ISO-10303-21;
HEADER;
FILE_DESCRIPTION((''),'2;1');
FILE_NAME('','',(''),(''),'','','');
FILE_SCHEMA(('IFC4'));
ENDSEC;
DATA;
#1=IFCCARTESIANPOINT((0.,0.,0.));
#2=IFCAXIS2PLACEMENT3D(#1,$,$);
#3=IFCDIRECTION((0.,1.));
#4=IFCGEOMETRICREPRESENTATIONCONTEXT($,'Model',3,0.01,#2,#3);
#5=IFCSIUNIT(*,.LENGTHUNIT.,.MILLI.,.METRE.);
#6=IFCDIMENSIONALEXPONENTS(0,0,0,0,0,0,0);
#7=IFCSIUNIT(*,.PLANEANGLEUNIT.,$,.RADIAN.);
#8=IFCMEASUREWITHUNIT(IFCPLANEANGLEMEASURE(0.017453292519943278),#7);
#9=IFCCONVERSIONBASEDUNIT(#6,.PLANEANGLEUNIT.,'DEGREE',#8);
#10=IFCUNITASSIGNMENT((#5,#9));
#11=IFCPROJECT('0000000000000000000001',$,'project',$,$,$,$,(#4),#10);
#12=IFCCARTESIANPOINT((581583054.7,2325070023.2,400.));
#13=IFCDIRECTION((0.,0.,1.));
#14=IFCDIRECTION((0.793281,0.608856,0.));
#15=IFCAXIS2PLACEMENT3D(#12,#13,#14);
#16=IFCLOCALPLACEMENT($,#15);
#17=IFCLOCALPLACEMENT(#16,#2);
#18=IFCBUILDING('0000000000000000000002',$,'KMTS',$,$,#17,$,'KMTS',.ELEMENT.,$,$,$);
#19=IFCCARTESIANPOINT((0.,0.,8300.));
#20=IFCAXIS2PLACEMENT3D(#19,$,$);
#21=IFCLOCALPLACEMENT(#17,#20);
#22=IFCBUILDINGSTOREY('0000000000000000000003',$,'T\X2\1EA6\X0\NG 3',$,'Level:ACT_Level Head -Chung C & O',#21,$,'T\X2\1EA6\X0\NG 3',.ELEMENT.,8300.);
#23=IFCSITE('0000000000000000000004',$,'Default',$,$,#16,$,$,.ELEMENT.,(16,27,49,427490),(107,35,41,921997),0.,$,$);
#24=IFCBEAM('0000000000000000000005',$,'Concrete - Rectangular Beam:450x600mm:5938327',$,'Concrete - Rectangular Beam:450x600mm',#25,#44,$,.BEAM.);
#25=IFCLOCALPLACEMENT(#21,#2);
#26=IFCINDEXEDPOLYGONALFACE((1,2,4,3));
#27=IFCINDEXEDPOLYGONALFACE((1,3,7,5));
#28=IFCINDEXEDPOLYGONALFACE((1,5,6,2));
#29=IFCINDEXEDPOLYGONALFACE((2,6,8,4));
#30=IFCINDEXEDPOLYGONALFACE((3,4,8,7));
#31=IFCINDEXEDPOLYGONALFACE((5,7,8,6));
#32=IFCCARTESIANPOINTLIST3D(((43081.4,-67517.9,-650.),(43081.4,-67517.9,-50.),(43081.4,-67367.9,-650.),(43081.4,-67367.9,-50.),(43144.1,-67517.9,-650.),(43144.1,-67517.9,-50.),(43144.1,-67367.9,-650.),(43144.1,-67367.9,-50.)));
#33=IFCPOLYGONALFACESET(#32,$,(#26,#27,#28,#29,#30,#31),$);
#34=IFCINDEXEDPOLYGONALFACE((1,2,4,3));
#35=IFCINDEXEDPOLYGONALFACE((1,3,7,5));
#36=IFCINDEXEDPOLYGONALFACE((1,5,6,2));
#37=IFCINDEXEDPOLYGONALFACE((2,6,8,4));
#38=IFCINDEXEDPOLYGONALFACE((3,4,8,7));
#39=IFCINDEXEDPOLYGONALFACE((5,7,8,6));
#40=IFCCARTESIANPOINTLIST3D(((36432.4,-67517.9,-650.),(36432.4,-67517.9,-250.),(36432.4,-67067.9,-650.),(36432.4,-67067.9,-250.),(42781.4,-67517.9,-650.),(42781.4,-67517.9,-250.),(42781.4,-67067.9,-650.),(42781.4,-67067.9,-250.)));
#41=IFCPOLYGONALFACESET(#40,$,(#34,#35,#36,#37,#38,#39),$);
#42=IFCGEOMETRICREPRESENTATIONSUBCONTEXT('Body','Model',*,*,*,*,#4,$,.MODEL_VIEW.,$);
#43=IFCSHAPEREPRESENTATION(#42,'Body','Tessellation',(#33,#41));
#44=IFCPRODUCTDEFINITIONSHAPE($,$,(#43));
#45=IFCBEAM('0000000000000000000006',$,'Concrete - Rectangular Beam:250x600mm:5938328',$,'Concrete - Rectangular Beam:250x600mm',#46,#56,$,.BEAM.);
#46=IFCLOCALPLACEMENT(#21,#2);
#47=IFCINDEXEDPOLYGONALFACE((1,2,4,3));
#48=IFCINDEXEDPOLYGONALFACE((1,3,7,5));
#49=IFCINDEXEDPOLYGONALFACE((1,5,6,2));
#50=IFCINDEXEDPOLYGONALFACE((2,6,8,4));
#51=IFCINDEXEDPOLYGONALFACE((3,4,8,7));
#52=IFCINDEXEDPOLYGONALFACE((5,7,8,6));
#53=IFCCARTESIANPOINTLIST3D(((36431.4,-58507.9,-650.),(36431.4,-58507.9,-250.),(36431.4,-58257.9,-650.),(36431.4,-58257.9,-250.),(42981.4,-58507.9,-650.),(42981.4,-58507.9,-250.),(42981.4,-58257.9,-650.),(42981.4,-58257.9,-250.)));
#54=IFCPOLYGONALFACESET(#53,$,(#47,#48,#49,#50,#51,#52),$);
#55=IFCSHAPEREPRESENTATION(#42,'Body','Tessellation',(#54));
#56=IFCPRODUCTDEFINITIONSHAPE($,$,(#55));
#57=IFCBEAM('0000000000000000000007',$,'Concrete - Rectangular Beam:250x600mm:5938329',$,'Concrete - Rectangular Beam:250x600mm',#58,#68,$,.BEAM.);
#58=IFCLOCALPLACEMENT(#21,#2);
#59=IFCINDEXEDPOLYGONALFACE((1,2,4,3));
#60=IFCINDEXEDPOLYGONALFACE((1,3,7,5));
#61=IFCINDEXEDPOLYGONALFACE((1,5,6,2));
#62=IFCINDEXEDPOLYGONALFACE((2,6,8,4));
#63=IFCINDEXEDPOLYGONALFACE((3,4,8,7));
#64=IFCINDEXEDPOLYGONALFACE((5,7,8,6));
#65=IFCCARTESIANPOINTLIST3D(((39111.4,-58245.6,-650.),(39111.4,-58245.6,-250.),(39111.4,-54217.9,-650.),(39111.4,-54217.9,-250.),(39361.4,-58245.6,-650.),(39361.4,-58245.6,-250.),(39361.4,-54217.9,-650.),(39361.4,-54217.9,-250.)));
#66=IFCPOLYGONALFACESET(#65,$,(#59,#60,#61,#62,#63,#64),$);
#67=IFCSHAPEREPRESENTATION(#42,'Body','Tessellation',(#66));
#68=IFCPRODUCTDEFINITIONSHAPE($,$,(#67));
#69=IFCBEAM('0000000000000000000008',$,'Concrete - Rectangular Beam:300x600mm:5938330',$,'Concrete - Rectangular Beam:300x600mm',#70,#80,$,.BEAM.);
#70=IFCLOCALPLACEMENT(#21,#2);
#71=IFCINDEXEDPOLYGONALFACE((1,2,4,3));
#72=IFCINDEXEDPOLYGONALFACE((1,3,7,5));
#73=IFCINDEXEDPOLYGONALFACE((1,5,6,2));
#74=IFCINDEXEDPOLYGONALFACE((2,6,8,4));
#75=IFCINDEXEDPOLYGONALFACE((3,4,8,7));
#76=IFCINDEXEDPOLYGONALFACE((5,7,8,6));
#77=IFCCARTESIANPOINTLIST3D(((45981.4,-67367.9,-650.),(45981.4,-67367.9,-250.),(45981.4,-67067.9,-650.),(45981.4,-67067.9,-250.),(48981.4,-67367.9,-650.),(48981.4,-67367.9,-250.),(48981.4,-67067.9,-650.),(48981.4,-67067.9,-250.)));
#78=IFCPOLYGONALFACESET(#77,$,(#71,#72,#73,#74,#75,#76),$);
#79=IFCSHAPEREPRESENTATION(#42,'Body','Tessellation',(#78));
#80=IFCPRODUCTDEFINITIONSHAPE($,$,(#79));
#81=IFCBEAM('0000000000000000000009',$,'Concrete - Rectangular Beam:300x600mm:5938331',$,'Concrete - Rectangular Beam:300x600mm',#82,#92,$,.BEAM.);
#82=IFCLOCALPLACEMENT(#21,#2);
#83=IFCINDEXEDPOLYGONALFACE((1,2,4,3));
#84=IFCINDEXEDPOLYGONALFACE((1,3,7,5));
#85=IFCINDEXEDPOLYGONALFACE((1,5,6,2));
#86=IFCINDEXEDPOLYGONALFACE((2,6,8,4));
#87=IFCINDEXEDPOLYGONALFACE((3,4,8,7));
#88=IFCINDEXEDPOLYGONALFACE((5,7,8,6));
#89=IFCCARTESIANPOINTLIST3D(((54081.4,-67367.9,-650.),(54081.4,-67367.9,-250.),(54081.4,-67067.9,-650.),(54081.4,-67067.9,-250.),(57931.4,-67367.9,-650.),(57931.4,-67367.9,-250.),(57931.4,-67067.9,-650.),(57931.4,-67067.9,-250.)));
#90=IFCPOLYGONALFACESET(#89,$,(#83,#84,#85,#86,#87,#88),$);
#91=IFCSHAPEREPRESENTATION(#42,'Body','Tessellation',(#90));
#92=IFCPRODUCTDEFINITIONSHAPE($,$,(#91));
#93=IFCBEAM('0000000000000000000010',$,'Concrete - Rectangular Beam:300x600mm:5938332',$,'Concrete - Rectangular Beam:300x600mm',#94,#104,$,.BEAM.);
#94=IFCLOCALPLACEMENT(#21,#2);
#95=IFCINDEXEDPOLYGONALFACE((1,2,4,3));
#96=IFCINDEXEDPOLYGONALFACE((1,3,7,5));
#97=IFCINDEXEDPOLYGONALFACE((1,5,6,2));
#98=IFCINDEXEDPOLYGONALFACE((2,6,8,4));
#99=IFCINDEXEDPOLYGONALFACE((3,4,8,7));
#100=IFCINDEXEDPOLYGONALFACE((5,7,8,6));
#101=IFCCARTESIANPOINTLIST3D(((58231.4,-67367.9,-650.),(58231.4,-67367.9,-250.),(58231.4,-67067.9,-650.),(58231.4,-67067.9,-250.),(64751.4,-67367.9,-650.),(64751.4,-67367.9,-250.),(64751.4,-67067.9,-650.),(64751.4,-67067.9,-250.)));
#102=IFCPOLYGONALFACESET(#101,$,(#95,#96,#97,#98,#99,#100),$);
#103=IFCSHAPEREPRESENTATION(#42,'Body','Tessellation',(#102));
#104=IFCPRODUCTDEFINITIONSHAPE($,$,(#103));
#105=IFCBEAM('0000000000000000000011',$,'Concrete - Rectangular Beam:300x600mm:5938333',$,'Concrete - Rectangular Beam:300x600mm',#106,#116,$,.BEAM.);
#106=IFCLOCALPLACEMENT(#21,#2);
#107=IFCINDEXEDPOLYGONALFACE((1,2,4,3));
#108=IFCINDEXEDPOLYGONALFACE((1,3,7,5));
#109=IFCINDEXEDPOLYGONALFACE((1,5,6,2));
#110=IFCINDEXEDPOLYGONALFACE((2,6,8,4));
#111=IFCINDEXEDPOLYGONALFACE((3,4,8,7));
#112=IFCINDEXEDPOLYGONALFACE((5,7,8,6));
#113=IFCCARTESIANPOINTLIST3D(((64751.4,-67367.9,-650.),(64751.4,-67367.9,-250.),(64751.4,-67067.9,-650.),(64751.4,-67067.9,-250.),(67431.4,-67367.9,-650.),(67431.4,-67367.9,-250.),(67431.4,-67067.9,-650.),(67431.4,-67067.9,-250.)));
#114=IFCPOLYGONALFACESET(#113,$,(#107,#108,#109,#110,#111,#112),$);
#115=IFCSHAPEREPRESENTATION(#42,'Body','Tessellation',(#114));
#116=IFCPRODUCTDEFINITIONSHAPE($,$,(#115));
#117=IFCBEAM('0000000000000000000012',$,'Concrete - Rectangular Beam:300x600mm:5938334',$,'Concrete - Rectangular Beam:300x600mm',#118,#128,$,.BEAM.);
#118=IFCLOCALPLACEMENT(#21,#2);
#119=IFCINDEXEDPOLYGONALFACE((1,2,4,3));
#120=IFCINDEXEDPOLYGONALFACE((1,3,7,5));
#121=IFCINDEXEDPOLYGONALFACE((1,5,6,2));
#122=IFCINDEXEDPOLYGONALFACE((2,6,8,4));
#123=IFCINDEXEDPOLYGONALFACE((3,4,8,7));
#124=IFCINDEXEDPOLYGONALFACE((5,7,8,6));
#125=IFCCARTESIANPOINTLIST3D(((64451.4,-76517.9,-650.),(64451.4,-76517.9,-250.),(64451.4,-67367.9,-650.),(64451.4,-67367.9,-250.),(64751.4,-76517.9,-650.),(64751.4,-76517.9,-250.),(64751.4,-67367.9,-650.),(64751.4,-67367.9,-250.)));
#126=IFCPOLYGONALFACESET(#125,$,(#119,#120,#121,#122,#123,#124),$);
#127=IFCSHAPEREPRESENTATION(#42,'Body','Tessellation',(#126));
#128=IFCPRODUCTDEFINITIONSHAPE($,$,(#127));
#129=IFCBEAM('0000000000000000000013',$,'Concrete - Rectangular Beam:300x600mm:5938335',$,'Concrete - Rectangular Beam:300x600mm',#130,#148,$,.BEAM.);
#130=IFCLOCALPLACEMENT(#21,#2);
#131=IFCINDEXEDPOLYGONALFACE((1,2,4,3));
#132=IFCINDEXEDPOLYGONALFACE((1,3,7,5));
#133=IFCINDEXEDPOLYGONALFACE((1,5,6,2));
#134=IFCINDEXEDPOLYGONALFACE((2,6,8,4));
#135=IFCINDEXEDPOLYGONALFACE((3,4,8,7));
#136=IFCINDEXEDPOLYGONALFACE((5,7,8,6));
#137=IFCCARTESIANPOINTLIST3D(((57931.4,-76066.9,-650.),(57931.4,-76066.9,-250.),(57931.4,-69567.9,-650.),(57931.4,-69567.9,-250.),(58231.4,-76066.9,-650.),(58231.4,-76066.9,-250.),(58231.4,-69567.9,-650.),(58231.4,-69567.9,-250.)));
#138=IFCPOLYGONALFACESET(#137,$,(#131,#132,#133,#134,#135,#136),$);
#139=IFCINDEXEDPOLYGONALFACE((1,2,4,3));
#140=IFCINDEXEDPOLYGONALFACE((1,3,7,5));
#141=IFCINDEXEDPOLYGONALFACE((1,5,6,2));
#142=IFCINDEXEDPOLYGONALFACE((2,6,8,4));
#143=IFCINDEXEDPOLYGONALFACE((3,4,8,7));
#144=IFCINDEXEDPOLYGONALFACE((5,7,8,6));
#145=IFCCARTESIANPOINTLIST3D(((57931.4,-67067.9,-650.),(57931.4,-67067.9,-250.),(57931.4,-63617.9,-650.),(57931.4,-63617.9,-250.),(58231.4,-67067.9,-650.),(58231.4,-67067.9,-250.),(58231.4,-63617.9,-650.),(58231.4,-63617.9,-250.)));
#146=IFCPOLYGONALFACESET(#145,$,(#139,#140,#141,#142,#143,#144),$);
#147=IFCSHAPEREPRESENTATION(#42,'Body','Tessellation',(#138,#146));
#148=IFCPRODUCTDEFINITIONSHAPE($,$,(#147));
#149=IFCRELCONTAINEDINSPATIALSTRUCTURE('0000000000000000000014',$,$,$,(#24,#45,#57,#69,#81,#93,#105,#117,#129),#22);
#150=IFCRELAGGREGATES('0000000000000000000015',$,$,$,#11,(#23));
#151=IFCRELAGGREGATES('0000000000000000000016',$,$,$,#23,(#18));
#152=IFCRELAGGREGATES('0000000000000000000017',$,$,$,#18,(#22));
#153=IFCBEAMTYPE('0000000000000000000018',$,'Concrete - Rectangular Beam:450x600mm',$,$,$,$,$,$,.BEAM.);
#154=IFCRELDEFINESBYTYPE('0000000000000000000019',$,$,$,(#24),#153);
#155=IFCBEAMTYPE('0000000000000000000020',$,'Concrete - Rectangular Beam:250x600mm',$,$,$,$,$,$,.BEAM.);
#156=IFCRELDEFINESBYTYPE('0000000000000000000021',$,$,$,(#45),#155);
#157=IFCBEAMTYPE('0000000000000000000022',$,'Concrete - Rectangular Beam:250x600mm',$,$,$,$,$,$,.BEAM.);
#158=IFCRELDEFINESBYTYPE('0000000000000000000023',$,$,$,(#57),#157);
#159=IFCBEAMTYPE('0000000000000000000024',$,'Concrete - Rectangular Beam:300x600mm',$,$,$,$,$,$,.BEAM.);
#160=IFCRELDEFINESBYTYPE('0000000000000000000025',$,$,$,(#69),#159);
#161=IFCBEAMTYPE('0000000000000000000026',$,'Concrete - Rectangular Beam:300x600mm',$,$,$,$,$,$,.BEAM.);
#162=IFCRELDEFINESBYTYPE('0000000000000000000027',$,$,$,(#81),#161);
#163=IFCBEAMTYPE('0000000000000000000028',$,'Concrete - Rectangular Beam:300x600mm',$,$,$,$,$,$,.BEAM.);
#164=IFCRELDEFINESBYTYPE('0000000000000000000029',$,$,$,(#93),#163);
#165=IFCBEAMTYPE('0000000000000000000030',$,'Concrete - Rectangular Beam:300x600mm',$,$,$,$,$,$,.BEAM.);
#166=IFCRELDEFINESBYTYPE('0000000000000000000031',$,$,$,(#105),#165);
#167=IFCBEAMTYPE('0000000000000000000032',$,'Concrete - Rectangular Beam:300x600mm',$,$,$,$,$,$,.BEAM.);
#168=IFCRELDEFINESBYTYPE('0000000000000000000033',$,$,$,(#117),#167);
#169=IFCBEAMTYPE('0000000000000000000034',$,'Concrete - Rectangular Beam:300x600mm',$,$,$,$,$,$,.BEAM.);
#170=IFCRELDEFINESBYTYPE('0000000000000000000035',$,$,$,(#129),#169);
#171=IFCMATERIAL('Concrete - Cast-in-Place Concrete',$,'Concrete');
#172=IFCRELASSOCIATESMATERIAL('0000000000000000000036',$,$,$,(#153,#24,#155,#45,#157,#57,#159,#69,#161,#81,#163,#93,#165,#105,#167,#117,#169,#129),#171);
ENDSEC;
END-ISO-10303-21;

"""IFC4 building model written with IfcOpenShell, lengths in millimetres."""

from ifc_helpers import new_model, entity, si_unit, converted_unit, direction, frame, origin, place, context, subcontext, project, spatial, indexed_curve, outline, extrude, source, transform, mapped, material, type_object, type_shapes, element, save


model = new_model("IFC4")

# Units and contexts
model_context = context("Model", 3, precision=0.01, world=origin(), true_north=direction((0.0, 1.0)))
body_context = subcontext(model_context, "Body", "Model", "MODEL_VIEW")
ifc_project = project(units=[si_unit("LENGTHUNIT", "METRE", prefix="MILLI"), converted_unit("PLANEANGLEUNIT", "DEGREE", entity("IfcPlaneAngleMeasure", 0.017453292519943278), si_unit("PLANEANGLEUNIT", "RADIAN"), dimensions=[0, 0, 0, 0, 0, 0, 0])], contexts=[model_context])

# Site, building, storey
site_placement = place(None, frame((581583054.7, 2325070023.2, 400.0), z_axis=(0.0, 0.0, 1.0), x_axis=(0.793281, 0.608856, 0.0)))
site = spatial("IfcSite", under=ifc_project, at=site_placement, Name="Default", CompositionType="ELEMENT", RefLatitude=(16, 27, 49, 427490), RefLongitude=(107, 35, 41, 921997), RefElevation=0.0)
building_placement = place(site_placement, origin())
building = spatial("IfcBuilding", under=site, at=building_placement, Name="KMTS", LongName="KMTS", CompositionType="ELEMENT")
storey_placement = place(building_placement, frame((0.0, 0.0, 8300.0)))
storey = spatial("IfcBuildingStorey", under=building, at=storey_placement, Name="TẦNG 3", ObjectType="Level:ACT_Level Head -Chung C & O", LongName="TẦNG 3", CompositionType="ELEMENT", Elevation=8300.0)

# Beams
ifc_material_1 = material(Name="Concrete - Cast-in-Place Concrete", Category="Concrete")
beam_type_1 = type_object("IfcBeamType", Name="Concrete - Rectangular Beam:450x600mm", PredefinedType="BEAM", material=ifc_material_1)
shared_shape_1 = source(origin(), body_context, "Body", "SweptSolid", [
    extrude(outline(indexed_curve([(-300.0, -75.0), (300.0, -75.0), (300.0, 75.0), (-300.0, 75.0), (-300.0, -75.0)], self_intersect=False)), frame((43081.4, -67442.9, 7950.0), z_axis=(1.0, 0.0, 0.0), x_axis=(0.0, 0.0, -1.0)), (0.0, 0.0, 1.0), 62.7),
    extrude(outline(indexed_curve([(-200.0, -225.0), (200.0, -225.0), (200.0, 225.0), (-200.0, 225.0), (-200.0, -225.0)], self_intersect=False)), frame((36432.4, -67292.9, 7850.0), z_axis=(1.0, 0.0, 0.0), x_axis=(0.0, 0.0, -1.0)), (0.0, 0.0, 1.0), 6349.0),
])
type_shapes(beam_type_1, [shared_shape_1])
beam_1_placement = place(storey_placement, frame((0.0, 0.0, -8300.0)))
element("IfcBeam", 1, at=beam_1_placement, inside=storey, type_object=beam_type_1, material=ifc_material_1, Name="Concrete - Rectangular Beam:450x600mm:5938327", ObjectType="Concrete - Rectangular Beam:450x600mm", PredefinedType="BEAM", context=body_context, shape_type="MappedRepresentation", body=[
    mapped(shared_shape_1, transform((0.0, 0.0, 0.0), scale=1.0)),
])
beam_type_2 = type_object("IfcBeamType", Name="Concrete - Rectangular Beam:250x600mm", PredefinedType="BEAM", material=ifc_material_1)
shared_shape_2 = source(origin(), body_context, "Body", "SweptSolid", [
    extrude(outline(indexed_curve([(-200.0, -125.0), (200.0, -125.0), (200.0, 125.0), (-200.0, 125.0), (-200.0, -125.0)], self_intersect=False)), frame((42981.4, -58382.9, 7850.0), z_axis=(-1.0, 0.0, 0.0), x_axis=(0.0, 0.0, -1.0)), (0.0, 0.0, 1.0), 6550.0),
])
type_shapes(beam_type_2, [shared_shape_2])
beam_2_placement = place(storey_placement, frame((0.0, 0.0, -8300.0)))
element("IfcBeam", 2, at=beam_2_placement, inside=storey, type_object=beam_type_2, material=ifc_material_1, Name="Concrete - Rectangular Beam:250x600mm:5938328", ObjectType="Concrete - Rectangular Beam:250x600mm", PredefinedType="BEAM", context=body_context, shape_type="MappedRepresentation", body=[
    mapped(shared_shape_2, transform((0.0, 0.0, 0.0), scale=1.0)),
])
beam_type_3 = type_object("IfcBeamType", Name="Concrete - Rectangular Beam:250x600mm", PredefinedType="BEAM", material=ifc_material_1)
shared_shape_3 = source(origin(), body_context, "Body", "SweptSolid", [
    extrude(outline(indexed_curve([(-125.0, -200.0), (125.0, -200.0), (125.0, 200.0), (-125.0, 200.0), (-125.0, -200.0)], self_intersect=False)), frame((39236.4, -54217.9, 7850.0), z_axis=(0.0, -1.0, 0.0), x_axis=(-1.0, 0.0, 0.0)), (0.0, 0.0, 1.0), 4027.7),
])
type_shapes(beam_type_3, [shared_shape_3])
beam_3_placement = place(storey_placement, frame((0.0, 0.0, -8300.0)))
element("IfcBeam", 3, at=beam_3_placement, inside=storey, type_object=beam_type_3, material=ifc_material_1, Name="Concrete - Rectangular Beam:250x600mm:5938329", ObjectType="Concrete - Rectangular Beam:250x600mm", PredefinedType="BEAM", context=body_context, shape_type="MappedRepresentation", body=[
    mapped(shared_shape_3, transform((0.0, 0.0, 0.0), scale=1.0)),
])
beam_type_4 = type_object("IfcBeamType", Name="Concrete - Rectangular Beam:300x600mm", PredefinedType="BEAM", material=ifc_material_1)
shared_shape_4 = source(origin(), body_context, "Body", "SweptSolid", [
    extrude(outline(indexed_curve([(-200.0, -150.0), (200.0, -150.0), (200.0, 150.0), (-200.0, 150.0), (-200.0, -150.0)], self_intersect=False)), frame((48981.4, -67217.9, 7850.0), z_axis=(-1.0, 0.0, 0.0), x_axis=(0.0, 0.0, -1.0)), (0.0, 0.0, 1.0), 3000.0),
])
type_shapes(beam_type_4, [shared_shape_4])
beam_4_placement = place(storey_placement, frame((0.0, 0.0, -8300.0)))
element("IfcBeam", 4, at=beam_4_placement, inside=storey, type_object=beam_type_4, material=ifc_material_1, Name="Concrete - Rectangular Beam:300x600mm:5938330", ObjectType="Concrete - Rectangular Beam:300x600mm", PredefinedType="BEAM", context=body_context, shape_type="MappedRepresentation", body=[
    mapped(shared_shape_4, transform((0.0, 0.0, 0.0), scale=1.0)),
])
beam_type_5 = type_object("IfcBeamType", Name="Concrete - Rectangular Beam:300x600mm", PredefinedType="BEAM", material=ifc_material_1)
shared_shape_5 = source(origin(), body_context, "Body", "SweptSolid", [
    extrude(outline(indexed_curve([(-200.0, -150.0), (200.0, -150.0), (200.0, 150.0), (-200.0, 150.0), (-200.0, -150.0)], self_intersect=False)), frame((54081.4, -67217.9, 7850.0), z_axis=(1.0, 0.0, 0.0), x_axis=(0.0, 0.0, -1.0)), (0.0, 0.0, 1.0), 3850.0),
])
type_shapes(beam_type_5, [shared_shape_5])
beam_5_placement = place(storey_placement, frame((0.0, 0.0, -8300.0)))
element("IfcBeam", 5, at=beam_5_placement, inside=storey, type_object=beam_type_5, material=ifc_material_1, Name="Concrete - Rectangular Beam:300x600mm:5938331", ObjectType="Concrete - Rectangular Beam:300x600mm", PredefinedType="BEAM", context=body_context, shape_type="MappedRepresentation", body=[
    mapped(shared_shape_5, transform((0.0, 0.0, 0.0), scale=1.0)),
])
beam_type_6 = type_object("IfcBeamType", Name="Concrete - Rectangular Beam:300x600mm", PredefinedType="BEAM", material=ifc_material_1)
shared_shape_6 = source(origin(), body_context, "Body", "SweptSolid", [
    extrude(outline(indexed_curve([(-200.0, -150.0), (200.0, -150.0), (200.0, 150.0), (-200.0, 150.0), (-200.0, -150.0)], self_intersect=False)), frame((58231.4, -67217.9, 7850.0), z_axis=(1.0, 0.0, 0.0), x_axis=(0.0, 0.0, -1.0)), (0.0, 0.0, 1.0), 6520.0),
])
type_shapes(beam_type_6, [shared_shape_6])
beam_6_placement = place(storey_placement, frame((0.0, 0.0, -8300.0)))
element("IfcBeam", 6, at=beam_6_placement, inside=storey, type_object=beam_type_6, material=ifc_material_1, Name="Concrete - Rectangular Beam:300x600mm:5938332", ObjectType="Concrete - Rectangular Beam:300x600mm", PredefinedType="BEAM", context=body_context, shape_type="MappedRepresentation", body=[
    mapped(shared_shape_6, transform((0.0, 0.0, 0.0), scale=1.0)),
])
beam_type_7 = type_object("IfcBeamType", Name="Concrete - Rectangular Beam:300x600mm", PredefinedType="BEAM", material=ifc_material_1)
shared_shape_7 = source(origin(), body_context, "Body", "SweptSolid", [
    extrude(outline(indexed_curve([(-200.0, -150.0), (200.0, -150.0), (200.0, 150.0), (-200.0, 150.0), (-200.0, -150.0)], self_intersect=False)), frame((67431.4, -67217.9, 7850.0), z_axis=(-1.0, 0.0, 0.0), x_axis=(0.0, 0.0, -1.0)), (0.0, 0.0, 1.0), 2680.0),
])
type_shapes(beam_type_7, [shared_shape_7])
beam_7_placement = place(storey_placement, frame((0.0, 0.0, -8300.0)))
element("IfcBeam", 7, at=beam_7_placement, inside=storey, type_object=beam_type_7, material=ifc_material_1, Name="Concrete - Rectangular Beam:300x600mm:5938333", ObjectType="Concrete - Rectangular Beam:300x600mm", PredefinedType="BEAM", context=body_context, shape_type="MappedRepresentation", body=[
    mapped(shared_shape_7, transform((0.0, 0.0, 0.0), scale=1.0)),
])
beam_type_8 = type_object("IfcBeamType", Name="Concrete - Rectangular Beam:300x600mm", PredefinedType="BEAM", material=ifc_material_1)
shared_shape_8 = source(origin(), body_context, "Body", "SweptSolid", [
    extrude(outline(indexed_curve([(-150.0, -200.0), (150.0, -200.0), (150.0, 200.0), (-150.0, 200.0), (-150.0, -200.0)], self_intersect=False)), frame((64601.4, -67367.9, 7850.0), z_axis=(0.0, -1.0, 0.0), x_axis=(-1.0, 0.0, 0.0)), (0.0, 0.0, 1.0), 9150.0),
])
type_shapes(beam_type_8, [shared_shape_8])
beam_8_placement = place(storey_placement, frame((0.0, 0.0, -8300.0)))
element("IfcBeam", 8, at=beam_8_placement, inside=storey, type_object=beam_type_8, material=ifc_material_1, Name="Concrete - Rectangular Beam:300x600mm:5938334", ObjectType="Concrete - Rectangular Beam:300x600mm", PredefinedType="BEAM", context=body_context, shape_type="MappedRepresentation", body=[
    mapped(shared_shape_8, transform((0.0, 0.0, 0.0), scale=1.0)),
])
beam_type_9 = type_object("IfcBeamType", Name="Concrete - Rectangular Beam:300x600mm", PredefinedType="BEAM", material=ifc_material_1)
shared_shape_9 = source(origin(), body_context, "Body", "SweptSolid", [
    extrude(outline(indexed_curve([(-150.0, -200.0), (150.0, -200.0), (150.0, 200.0), (-150.0, 200.0), (-150.0, -200.0)], self_intersect=False)), frame((58081.4, -69567.9, 7850.0), z_axis=(0.0, -1.0, 0.0), x_axis=(-1.0, 0.0, 0.0)), (0.0, 0.0, 1.0), 6499.0),
    extrude(outline(indexed_curve([(-150.0, -200.0), (150.0, -200.0), (150.0, 200.0), (-150.0, 200.0), (-150.0, -200.0)], self_intersect=False)), frame((58081.4, -63617.9, 7850.0), z_axis=(0.0, -1.0, 0.0), x_axis=(-1.0, 0.0, 0.0)), (0.0, 0.0, 1.0), 3450.0),
])
type_shapes(beam_type_9, [shared_shape_9])
beam_9_placement = place(storey_placement, frame((0.0, 0.0, -8300.0)))
element("IfcBeam", 9, at=beam_9_placement, inside=storey, type_object=beam_type_9, material=ifc_material_1, Name="Concrete - Rectangular Beam:300x600mm:5938335", ObjectType="Concrete - Rectangular Beam:300x600mm", PredefinedType="BEAM", context=body_context, shape_type="MappedRepresentation", body=[
    mapped(shared_shape_9, transform((0.0, 0.0, 0.0), scale=1.0)),
])

save(model, "model.ifc")
